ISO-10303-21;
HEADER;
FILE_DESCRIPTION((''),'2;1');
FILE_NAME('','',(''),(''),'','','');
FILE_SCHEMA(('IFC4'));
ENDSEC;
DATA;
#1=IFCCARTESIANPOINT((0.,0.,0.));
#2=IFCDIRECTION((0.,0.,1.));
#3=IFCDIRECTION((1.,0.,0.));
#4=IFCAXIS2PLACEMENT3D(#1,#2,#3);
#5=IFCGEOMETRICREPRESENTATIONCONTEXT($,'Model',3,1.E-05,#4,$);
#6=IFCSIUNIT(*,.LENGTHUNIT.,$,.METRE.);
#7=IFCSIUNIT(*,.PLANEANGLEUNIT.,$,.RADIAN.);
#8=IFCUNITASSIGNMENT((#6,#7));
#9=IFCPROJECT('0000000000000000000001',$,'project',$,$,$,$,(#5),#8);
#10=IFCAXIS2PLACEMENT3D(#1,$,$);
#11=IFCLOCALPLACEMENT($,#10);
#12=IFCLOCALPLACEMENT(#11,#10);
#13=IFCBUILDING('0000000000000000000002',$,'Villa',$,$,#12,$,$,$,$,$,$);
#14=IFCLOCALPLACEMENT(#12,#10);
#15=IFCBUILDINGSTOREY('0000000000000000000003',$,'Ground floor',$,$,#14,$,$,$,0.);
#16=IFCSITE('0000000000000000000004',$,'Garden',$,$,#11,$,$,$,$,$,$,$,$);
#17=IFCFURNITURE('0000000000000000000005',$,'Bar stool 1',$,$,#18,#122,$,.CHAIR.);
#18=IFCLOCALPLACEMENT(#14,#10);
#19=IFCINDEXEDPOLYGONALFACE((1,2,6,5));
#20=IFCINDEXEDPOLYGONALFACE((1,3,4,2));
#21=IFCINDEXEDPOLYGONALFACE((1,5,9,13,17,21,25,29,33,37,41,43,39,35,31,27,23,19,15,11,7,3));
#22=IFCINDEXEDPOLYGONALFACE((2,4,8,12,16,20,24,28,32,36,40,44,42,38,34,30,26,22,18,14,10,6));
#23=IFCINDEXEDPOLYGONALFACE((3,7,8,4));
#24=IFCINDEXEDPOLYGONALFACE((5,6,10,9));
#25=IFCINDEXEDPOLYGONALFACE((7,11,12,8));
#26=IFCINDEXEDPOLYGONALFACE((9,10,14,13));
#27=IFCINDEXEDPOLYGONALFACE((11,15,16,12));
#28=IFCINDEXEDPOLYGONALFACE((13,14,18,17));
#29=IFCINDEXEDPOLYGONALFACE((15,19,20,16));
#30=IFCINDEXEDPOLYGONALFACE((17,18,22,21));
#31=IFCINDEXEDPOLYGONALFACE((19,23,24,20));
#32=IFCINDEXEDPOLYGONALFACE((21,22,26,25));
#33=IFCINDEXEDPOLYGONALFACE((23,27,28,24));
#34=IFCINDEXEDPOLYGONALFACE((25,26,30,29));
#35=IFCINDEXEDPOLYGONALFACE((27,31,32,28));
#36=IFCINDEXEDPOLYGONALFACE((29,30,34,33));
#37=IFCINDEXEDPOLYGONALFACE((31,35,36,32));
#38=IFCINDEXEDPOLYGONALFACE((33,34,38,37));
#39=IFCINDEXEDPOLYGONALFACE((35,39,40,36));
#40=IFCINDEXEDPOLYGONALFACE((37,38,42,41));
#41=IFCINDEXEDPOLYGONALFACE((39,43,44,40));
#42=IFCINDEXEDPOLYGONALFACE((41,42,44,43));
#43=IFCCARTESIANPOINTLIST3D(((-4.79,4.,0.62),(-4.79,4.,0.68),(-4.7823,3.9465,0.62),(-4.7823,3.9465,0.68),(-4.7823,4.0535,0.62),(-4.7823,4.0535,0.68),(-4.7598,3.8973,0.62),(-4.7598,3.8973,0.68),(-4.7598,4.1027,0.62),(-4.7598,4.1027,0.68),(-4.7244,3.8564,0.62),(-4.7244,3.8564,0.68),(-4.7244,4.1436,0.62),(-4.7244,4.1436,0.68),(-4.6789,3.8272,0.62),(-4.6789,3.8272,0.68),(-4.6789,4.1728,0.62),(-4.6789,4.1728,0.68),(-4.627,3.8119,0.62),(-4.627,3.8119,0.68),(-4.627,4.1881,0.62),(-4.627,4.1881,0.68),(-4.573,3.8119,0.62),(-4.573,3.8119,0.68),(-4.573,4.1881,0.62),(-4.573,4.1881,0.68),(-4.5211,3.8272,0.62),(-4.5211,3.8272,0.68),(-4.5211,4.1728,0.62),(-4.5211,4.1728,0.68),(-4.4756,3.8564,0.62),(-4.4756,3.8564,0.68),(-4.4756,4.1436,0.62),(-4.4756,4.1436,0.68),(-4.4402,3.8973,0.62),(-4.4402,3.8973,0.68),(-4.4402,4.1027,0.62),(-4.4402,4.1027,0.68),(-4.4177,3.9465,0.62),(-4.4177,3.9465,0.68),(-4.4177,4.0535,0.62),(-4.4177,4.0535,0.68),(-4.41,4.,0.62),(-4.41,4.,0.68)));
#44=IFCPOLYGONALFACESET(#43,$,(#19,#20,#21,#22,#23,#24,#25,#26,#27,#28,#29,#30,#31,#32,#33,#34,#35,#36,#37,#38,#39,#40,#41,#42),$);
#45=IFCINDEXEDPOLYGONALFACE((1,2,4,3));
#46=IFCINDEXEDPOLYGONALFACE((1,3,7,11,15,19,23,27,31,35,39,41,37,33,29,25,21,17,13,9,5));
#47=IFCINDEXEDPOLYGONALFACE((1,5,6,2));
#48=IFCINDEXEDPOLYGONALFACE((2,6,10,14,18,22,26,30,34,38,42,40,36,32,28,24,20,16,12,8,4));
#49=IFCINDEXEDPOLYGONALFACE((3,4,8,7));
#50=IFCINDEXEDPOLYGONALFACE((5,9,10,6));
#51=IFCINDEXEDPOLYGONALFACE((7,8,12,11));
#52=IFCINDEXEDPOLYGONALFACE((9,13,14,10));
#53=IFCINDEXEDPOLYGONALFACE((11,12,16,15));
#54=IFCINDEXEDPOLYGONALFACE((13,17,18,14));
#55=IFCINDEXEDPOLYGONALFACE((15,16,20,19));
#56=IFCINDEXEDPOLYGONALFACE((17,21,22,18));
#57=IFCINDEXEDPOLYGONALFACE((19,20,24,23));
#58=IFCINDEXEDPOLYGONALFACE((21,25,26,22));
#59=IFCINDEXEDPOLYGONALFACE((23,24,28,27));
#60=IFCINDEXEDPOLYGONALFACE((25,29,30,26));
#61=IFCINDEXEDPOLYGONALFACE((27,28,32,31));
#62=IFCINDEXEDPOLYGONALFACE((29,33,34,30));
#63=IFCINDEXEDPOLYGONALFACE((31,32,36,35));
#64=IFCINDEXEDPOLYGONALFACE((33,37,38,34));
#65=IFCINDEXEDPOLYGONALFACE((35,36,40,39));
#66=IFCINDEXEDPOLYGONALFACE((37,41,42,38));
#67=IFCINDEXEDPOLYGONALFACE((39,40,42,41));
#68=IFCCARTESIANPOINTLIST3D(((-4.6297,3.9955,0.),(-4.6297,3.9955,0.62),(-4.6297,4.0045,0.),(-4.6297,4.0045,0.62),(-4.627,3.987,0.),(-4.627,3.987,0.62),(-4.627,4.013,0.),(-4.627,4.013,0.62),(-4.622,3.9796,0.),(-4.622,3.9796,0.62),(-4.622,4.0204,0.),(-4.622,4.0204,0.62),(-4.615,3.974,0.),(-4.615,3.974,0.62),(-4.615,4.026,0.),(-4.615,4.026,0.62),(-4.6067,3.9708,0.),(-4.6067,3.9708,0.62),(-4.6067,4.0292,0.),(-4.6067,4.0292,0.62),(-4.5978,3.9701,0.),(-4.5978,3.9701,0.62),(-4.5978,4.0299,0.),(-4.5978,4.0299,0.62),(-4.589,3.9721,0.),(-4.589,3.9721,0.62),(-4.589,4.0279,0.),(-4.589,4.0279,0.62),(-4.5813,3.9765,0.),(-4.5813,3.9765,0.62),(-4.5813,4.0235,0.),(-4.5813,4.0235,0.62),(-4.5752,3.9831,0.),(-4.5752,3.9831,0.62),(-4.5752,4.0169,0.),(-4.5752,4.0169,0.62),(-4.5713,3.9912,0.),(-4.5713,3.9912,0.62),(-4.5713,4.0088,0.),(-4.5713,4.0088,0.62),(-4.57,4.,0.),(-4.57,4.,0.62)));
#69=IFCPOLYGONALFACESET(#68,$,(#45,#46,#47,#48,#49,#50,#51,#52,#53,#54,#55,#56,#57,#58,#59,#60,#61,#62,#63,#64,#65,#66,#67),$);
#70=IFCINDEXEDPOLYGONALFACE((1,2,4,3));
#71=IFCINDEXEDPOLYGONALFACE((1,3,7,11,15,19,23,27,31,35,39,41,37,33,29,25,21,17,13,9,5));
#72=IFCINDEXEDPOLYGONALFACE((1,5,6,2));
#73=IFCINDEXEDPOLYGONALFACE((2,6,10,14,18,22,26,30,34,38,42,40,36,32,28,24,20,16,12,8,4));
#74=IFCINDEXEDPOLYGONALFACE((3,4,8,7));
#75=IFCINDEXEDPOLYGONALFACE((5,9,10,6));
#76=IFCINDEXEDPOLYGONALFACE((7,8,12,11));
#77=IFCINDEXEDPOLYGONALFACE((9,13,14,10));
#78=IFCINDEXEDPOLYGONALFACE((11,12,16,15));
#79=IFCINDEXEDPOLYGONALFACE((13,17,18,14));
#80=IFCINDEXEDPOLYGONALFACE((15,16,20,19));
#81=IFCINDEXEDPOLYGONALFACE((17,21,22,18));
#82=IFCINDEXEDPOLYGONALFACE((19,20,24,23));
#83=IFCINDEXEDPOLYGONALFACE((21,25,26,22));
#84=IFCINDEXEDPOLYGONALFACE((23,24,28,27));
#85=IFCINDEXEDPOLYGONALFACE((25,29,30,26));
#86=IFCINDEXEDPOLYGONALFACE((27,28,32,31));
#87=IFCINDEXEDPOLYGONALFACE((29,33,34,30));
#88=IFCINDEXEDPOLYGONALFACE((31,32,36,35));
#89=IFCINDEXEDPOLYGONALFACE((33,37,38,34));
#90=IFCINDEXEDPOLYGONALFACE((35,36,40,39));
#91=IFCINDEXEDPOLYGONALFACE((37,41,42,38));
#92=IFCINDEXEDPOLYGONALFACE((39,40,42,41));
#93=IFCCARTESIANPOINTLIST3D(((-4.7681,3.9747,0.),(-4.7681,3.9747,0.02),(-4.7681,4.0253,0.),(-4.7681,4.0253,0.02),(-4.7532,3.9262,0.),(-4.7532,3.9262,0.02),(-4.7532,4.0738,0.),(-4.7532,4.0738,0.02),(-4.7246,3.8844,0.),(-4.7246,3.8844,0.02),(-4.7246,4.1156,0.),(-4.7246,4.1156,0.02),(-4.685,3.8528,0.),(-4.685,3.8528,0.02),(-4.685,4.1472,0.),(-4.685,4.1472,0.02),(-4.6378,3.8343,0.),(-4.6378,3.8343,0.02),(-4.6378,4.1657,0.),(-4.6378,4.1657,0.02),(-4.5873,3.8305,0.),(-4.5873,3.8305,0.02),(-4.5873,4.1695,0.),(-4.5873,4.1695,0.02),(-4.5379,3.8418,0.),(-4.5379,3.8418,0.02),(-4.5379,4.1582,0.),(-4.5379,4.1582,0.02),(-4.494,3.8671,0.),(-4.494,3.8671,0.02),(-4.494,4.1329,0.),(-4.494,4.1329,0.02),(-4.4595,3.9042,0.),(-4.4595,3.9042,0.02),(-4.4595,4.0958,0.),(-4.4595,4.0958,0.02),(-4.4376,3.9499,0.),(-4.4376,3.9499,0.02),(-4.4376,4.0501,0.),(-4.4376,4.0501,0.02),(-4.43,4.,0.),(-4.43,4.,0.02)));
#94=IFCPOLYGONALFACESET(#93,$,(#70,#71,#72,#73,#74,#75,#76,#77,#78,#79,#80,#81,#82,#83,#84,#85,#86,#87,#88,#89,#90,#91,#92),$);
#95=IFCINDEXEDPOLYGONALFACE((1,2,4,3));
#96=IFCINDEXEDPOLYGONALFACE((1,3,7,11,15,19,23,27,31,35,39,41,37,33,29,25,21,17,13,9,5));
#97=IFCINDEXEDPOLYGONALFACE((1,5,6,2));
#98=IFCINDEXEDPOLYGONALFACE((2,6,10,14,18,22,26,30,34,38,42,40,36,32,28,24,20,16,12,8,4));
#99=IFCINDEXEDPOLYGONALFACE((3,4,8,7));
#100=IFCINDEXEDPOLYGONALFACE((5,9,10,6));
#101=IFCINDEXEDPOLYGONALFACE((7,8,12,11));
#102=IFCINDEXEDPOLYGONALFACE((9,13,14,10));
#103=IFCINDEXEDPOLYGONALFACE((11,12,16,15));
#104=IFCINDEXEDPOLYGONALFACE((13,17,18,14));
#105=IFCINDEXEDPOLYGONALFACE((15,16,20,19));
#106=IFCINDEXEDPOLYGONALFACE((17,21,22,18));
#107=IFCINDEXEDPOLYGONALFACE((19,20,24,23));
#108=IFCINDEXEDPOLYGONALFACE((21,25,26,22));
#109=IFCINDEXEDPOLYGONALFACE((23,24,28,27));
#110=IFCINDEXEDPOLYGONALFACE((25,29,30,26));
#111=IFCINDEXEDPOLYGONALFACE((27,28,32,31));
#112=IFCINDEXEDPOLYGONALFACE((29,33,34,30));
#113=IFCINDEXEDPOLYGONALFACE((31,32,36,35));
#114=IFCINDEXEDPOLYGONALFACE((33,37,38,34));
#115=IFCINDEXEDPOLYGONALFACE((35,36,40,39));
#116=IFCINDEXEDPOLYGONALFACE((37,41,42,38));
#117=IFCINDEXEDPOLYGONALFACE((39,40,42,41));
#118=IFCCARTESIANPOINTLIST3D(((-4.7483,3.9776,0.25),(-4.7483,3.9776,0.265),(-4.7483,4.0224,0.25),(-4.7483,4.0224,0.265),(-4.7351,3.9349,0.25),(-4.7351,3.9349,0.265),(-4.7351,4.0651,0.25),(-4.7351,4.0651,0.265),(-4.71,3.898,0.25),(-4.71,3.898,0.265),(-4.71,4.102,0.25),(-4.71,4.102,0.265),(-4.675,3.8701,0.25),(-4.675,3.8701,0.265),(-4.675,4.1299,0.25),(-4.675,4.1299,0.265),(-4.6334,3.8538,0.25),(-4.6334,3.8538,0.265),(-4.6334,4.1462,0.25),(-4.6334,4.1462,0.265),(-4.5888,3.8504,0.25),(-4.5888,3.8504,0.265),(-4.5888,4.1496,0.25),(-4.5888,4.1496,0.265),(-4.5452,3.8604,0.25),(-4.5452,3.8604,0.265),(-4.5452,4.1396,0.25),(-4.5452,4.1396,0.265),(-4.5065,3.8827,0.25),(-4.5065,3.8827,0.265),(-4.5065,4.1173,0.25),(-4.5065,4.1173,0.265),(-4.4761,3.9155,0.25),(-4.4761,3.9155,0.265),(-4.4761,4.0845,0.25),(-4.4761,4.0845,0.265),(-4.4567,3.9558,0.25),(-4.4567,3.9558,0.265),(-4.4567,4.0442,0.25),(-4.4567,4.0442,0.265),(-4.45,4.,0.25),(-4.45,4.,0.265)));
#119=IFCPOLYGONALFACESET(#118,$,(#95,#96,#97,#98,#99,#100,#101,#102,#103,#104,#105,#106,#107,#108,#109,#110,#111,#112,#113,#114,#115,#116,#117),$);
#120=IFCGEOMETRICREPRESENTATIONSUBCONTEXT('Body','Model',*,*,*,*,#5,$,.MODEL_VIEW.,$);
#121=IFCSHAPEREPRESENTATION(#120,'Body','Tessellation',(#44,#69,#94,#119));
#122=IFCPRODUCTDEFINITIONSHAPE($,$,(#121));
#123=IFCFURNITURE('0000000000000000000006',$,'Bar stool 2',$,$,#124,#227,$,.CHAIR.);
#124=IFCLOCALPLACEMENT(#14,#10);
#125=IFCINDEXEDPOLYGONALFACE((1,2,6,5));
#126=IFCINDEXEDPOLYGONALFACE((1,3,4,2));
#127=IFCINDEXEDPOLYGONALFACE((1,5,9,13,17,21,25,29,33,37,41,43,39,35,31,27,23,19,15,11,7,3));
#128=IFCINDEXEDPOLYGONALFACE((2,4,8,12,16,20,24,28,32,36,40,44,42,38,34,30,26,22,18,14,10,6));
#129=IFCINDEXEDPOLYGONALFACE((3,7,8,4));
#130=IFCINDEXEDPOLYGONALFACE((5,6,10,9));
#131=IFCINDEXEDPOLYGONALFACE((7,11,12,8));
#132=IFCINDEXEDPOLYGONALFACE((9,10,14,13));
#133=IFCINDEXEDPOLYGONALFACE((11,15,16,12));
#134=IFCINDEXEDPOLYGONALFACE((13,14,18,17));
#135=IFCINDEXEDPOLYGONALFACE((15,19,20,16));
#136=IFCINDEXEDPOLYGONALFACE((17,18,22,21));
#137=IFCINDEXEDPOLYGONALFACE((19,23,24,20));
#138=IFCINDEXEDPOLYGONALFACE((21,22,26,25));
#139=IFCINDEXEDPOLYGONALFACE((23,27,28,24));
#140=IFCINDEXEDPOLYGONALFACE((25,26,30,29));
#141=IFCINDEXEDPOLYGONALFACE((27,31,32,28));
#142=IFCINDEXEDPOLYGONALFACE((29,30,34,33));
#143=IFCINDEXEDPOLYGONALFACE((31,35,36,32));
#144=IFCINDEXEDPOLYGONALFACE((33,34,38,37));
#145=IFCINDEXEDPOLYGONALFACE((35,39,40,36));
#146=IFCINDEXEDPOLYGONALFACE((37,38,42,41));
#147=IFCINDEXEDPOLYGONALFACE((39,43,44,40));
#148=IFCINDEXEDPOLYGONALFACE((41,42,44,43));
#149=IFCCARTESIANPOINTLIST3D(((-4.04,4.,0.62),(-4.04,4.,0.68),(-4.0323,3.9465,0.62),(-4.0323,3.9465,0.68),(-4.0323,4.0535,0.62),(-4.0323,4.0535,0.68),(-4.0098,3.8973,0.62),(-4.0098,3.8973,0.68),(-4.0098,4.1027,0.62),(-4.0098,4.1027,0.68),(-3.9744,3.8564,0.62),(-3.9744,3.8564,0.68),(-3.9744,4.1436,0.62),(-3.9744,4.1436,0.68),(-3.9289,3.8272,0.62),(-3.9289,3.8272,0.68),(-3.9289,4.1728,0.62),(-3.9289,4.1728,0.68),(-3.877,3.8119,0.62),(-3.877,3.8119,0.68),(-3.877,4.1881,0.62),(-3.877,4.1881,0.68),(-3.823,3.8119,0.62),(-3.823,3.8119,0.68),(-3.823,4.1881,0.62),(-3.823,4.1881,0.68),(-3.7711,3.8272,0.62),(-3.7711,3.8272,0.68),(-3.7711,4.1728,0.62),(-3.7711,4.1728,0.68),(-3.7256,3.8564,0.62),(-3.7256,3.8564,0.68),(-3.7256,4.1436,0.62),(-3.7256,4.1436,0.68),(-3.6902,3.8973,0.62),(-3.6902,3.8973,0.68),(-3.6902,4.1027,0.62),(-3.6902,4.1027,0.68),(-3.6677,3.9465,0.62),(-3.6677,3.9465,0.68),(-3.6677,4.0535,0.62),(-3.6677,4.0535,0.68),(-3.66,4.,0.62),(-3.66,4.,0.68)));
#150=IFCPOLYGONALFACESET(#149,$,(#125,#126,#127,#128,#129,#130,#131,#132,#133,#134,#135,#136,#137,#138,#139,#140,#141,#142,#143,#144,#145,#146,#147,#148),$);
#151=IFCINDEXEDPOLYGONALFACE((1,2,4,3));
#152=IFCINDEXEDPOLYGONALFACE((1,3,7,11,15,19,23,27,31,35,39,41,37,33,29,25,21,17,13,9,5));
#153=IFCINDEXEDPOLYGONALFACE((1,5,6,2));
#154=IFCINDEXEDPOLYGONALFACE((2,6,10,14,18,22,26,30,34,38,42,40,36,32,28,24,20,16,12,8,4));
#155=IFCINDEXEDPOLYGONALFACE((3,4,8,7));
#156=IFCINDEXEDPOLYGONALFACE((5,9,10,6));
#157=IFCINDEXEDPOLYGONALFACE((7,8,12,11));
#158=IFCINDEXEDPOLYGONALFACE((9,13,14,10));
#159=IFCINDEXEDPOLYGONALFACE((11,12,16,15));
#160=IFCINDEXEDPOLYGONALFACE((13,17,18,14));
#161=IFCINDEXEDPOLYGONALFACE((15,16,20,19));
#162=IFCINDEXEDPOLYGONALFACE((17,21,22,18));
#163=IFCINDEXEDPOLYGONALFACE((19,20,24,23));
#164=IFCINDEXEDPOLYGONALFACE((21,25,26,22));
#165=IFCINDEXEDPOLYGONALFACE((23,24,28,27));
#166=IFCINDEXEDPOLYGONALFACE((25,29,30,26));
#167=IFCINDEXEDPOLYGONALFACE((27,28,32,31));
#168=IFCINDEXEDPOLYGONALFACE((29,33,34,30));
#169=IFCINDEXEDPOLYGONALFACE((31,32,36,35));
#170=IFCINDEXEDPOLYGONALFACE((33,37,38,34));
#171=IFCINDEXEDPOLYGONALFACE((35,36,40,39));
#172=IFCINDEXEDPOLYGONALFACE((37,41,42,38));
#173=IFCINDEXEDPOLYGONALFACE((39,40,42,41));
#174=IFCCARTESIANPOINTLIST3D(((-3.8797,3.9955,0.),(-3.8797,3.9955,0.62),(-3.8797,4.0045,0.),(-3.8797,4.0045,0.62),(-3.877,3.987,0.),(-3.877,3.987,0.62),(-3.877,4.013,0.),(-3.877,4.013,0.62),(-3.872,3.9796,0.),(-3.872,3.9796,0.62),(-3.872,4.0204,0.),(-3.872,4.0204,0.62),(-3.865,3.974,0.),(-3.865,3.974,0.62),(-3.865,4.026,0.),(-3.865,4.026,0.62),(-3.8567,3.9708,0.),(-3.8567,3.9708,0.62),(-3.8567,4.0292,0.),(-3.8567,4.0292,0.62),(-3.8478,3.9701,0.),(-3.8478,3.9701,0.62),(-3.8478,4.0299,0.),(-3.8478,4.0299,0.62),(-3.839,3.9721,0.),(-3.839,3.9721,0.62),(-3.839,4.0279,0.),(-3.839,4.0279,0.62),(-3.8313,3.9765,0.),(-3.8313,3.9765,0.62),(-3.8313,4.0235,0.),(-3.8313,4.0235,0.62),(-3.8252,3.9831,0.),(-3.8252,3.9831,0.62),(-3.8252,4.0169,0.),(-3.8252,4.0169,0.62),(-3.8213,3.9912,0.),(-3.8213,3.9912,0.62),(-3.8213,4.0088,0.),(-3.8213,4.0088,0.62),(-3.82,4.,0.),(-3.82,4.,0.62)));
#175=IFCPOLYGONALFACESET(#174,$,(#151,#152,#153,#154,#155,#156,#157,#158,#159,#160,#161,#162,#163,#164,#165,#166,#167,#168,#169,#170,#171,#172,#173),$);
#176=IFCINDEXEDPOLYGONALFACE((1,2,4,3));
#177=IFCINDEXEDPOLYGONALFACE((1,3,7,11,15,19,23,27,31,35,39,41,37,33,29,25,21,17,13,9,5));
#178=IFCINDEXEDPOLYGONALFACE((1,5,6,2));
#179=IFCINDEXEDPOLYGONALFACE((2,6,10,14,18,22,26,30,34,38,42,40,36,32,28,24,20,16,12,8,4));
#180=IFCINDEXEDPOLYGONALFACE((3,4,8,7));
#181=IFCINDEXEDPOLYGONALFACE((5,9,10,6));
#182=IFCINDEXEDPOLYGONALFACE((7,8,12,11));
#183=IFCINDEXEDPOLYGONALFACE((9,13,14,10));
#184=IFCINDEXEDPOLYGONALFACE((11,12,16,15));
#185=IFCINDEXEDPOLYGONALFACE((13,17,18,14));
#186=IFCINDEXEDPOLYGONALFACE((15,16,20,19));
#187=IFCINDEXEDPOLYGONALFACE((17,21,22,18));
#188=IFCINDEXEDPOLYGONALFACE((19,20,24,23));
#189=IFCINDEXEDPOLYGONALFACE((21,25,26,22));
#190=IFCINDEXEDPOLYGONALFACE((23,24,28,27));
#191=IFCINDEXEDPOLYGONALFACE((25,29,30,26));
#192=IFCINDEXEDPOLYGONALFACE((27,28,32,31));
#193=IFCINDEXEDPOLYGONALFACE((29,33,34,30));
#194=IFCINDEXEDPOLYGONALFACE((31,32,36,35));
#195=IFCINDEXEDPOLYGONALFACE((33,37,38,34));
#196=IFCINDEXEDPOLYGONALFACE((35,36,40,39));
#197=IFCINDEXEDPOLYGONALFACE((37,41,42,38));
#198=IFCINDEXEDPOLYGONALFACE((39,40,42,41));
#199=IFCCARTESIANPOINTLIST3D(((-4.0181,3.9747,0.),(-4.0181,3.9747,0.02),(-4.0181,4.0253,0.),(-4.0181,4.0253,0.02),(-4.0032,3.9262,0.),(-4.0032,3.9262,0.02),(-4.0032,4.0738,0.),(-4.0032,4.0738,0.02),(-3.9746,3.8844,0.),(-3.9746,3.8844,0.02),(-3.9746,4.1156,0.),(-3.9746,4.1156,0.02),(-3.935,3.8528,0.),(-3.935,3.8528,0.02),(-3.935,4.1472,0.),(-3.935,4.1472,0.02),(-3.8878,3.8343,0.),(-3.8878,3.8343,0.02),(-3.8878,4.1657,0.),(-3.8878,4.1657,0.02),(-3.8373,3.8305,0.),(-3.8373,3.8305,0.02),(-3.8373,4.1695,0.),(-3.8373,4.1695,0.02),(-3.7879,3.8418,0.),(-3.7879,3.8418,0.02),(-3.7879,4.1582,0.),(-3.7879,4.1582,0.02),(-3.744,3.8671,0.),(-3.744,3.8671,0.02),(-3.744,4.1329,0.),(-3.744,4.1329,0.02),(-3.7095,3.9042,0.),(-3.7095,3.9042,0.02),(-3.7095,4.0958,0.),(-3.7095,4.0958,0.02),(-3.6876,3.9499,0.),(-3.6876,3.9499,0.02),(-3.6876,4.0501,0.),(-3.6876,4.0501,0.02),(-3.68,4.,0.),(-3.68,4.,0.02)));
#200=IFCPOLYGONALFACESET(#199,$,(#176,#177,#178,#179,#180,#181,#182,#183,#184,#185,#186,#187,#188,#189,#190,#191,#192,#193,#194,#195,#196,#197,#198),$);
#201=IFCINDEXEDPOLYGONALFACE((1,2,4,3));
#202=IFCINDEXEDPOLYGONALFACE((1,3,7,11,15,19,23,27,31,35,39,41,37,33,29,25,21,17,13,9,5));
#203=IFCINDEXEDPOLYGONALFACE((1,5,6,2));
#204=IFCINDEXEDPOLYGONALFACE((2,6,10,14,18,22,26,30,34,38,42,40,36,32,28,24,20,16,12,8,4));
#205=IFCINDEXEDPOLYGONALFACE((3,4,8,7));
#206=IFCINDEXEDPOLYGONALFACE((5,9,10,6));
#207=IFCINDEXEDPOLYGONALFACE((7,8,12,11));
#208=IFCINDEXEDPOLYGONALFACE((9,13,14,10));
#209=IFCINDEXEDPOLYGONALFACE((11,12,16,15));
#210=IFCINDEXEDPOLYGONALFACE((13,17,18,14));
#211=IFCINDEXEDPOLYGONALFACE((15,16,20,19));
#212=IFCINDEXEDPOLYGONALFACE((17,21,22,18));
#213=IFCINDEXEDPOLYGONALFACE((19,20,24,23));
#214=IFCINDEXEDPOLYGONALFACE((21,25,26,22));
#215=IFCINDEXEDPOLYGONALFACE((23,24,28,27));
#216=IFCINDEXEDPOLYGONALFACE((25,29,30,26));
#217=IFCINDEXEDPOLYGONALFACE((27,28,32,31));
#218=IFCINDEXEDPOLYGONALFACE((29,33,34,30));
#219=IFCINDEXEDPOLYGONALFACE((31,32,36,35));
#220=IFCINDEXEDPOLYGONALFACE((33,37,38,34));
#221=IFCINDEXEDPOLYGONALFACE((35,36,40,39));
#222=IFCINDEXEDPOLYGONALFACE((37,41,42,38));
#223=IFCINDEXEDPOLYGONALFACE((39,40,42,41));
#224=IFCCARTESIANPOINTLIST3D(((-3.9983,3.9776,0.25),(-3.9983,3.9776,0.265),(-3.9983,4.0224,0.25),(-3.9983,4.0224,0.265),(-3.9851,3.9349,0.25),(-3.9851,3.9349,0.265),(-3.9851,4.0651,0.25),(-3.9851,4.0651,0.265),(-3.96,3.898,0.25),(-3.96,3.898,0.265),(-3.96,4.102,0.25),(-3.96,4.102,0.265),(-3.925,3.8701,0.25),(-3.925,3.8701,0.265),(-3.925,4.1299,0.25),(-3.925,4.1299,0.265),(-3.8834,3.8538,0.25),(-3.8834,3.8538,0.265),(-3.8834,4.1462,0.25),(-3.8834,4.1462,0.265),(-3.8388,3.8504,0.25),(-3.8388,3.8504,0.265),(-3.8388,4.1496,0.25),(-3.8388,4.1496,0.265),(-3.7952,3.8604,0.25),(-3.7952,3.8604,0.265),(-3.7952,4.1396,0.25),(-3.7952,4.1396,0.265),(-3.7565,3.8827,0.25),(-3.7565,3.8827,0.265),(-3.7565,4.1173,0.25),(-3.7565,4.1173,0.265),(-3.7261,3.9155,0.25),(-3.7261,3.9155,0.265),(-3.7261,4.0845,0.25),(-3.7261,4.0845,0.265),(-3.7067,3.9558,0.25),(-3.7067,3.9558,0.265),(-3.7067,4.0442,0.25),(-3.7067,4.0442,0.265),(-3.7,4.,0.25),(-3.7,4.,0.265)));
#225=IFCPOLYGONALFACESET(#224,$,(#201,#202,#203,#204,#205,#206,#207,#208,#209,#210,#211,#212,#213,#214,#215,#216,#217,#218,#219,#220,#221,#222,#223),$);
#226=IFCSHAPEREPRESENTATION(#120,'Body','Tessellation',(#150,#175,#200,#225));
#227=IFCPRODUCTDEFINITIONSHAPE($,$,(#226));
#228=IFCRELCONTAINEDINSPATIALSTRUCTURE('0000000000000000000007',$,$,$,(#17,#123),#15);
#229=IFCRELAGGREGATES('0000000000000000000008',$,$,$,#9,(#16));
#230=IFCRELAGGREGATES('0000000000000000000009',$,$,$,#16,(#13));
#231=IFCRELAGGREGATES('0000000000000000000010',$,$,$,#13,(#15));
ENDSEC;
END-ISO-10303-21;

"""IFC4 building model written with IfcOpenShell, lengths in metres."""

from ifc_helpers import new_model, si_unit, frame, origin, origin_with_axes, origin_2d, place, context, subcontext, project, spatial, circle, extrude, element, save


model = new_model("IFC4")

# Units and contexts
model_context = context("Model", 3, precision=1e-05, world=origin_with_axes())
body_context = subcontext(model_context, "Body", "Model", "MODEL_VIEW")
ifc_project = project(units=[si_unit("LENGTHUNIT", "METRE"), si_unit("PLANEANGLEUNIT", "RADIAN")], contexts=[model_context])

# Site, building, storey
site_placement = place(None, origin())
site = spatial("IfcSite", under=ifc_project, at=site_placement, Name="Garden")
building_placement = place(site_placement, origin())
building = spatial("IfcBuilding", under=site, at=building_placement, Name="Villa")
storey_placement = place(building_placement, origin())
storey = spatial("IfcBuildingStorey", under=building, at=storey_placement, Name="Ground floor", Elevation=0.0)

# Furniture
for number, where, name in (
    (1, (-4.6, 4.0, 0.0), "Bar stool 1"),
    (2, (-3.85, 4.0, 0.0), "Bar stool 2"),
):
    element("IfcFurniture", number, at=place(storey_placement, frame(where)), inside=storey, Name=name, PredefinedType="CHAIR", context=body_context, shape_type="SweptSolid", body=[
        extrude(circle(Radius=0.19, at=origin_2d()), frame((0.0, 0.0, 0.62)), (0.0, 0.0, 1.0), 0.06),
        extrude(circle(Radius=0.03, at=origin_2d()), origin(), (0.0, 0.0, 1.0), 0.62),
        extrude(circle(Radius=0.17, at=origin_2d()), origin(), (0.0, 0.0, 1.0), 0.02),
        extrude(circle(Radius=0.15, at=origin_2d()), frame((0.0, 0.0, 0.25)), (0.0, 0.0, 1.0), 0.015),
    ])

save(model, "model.ifc")
